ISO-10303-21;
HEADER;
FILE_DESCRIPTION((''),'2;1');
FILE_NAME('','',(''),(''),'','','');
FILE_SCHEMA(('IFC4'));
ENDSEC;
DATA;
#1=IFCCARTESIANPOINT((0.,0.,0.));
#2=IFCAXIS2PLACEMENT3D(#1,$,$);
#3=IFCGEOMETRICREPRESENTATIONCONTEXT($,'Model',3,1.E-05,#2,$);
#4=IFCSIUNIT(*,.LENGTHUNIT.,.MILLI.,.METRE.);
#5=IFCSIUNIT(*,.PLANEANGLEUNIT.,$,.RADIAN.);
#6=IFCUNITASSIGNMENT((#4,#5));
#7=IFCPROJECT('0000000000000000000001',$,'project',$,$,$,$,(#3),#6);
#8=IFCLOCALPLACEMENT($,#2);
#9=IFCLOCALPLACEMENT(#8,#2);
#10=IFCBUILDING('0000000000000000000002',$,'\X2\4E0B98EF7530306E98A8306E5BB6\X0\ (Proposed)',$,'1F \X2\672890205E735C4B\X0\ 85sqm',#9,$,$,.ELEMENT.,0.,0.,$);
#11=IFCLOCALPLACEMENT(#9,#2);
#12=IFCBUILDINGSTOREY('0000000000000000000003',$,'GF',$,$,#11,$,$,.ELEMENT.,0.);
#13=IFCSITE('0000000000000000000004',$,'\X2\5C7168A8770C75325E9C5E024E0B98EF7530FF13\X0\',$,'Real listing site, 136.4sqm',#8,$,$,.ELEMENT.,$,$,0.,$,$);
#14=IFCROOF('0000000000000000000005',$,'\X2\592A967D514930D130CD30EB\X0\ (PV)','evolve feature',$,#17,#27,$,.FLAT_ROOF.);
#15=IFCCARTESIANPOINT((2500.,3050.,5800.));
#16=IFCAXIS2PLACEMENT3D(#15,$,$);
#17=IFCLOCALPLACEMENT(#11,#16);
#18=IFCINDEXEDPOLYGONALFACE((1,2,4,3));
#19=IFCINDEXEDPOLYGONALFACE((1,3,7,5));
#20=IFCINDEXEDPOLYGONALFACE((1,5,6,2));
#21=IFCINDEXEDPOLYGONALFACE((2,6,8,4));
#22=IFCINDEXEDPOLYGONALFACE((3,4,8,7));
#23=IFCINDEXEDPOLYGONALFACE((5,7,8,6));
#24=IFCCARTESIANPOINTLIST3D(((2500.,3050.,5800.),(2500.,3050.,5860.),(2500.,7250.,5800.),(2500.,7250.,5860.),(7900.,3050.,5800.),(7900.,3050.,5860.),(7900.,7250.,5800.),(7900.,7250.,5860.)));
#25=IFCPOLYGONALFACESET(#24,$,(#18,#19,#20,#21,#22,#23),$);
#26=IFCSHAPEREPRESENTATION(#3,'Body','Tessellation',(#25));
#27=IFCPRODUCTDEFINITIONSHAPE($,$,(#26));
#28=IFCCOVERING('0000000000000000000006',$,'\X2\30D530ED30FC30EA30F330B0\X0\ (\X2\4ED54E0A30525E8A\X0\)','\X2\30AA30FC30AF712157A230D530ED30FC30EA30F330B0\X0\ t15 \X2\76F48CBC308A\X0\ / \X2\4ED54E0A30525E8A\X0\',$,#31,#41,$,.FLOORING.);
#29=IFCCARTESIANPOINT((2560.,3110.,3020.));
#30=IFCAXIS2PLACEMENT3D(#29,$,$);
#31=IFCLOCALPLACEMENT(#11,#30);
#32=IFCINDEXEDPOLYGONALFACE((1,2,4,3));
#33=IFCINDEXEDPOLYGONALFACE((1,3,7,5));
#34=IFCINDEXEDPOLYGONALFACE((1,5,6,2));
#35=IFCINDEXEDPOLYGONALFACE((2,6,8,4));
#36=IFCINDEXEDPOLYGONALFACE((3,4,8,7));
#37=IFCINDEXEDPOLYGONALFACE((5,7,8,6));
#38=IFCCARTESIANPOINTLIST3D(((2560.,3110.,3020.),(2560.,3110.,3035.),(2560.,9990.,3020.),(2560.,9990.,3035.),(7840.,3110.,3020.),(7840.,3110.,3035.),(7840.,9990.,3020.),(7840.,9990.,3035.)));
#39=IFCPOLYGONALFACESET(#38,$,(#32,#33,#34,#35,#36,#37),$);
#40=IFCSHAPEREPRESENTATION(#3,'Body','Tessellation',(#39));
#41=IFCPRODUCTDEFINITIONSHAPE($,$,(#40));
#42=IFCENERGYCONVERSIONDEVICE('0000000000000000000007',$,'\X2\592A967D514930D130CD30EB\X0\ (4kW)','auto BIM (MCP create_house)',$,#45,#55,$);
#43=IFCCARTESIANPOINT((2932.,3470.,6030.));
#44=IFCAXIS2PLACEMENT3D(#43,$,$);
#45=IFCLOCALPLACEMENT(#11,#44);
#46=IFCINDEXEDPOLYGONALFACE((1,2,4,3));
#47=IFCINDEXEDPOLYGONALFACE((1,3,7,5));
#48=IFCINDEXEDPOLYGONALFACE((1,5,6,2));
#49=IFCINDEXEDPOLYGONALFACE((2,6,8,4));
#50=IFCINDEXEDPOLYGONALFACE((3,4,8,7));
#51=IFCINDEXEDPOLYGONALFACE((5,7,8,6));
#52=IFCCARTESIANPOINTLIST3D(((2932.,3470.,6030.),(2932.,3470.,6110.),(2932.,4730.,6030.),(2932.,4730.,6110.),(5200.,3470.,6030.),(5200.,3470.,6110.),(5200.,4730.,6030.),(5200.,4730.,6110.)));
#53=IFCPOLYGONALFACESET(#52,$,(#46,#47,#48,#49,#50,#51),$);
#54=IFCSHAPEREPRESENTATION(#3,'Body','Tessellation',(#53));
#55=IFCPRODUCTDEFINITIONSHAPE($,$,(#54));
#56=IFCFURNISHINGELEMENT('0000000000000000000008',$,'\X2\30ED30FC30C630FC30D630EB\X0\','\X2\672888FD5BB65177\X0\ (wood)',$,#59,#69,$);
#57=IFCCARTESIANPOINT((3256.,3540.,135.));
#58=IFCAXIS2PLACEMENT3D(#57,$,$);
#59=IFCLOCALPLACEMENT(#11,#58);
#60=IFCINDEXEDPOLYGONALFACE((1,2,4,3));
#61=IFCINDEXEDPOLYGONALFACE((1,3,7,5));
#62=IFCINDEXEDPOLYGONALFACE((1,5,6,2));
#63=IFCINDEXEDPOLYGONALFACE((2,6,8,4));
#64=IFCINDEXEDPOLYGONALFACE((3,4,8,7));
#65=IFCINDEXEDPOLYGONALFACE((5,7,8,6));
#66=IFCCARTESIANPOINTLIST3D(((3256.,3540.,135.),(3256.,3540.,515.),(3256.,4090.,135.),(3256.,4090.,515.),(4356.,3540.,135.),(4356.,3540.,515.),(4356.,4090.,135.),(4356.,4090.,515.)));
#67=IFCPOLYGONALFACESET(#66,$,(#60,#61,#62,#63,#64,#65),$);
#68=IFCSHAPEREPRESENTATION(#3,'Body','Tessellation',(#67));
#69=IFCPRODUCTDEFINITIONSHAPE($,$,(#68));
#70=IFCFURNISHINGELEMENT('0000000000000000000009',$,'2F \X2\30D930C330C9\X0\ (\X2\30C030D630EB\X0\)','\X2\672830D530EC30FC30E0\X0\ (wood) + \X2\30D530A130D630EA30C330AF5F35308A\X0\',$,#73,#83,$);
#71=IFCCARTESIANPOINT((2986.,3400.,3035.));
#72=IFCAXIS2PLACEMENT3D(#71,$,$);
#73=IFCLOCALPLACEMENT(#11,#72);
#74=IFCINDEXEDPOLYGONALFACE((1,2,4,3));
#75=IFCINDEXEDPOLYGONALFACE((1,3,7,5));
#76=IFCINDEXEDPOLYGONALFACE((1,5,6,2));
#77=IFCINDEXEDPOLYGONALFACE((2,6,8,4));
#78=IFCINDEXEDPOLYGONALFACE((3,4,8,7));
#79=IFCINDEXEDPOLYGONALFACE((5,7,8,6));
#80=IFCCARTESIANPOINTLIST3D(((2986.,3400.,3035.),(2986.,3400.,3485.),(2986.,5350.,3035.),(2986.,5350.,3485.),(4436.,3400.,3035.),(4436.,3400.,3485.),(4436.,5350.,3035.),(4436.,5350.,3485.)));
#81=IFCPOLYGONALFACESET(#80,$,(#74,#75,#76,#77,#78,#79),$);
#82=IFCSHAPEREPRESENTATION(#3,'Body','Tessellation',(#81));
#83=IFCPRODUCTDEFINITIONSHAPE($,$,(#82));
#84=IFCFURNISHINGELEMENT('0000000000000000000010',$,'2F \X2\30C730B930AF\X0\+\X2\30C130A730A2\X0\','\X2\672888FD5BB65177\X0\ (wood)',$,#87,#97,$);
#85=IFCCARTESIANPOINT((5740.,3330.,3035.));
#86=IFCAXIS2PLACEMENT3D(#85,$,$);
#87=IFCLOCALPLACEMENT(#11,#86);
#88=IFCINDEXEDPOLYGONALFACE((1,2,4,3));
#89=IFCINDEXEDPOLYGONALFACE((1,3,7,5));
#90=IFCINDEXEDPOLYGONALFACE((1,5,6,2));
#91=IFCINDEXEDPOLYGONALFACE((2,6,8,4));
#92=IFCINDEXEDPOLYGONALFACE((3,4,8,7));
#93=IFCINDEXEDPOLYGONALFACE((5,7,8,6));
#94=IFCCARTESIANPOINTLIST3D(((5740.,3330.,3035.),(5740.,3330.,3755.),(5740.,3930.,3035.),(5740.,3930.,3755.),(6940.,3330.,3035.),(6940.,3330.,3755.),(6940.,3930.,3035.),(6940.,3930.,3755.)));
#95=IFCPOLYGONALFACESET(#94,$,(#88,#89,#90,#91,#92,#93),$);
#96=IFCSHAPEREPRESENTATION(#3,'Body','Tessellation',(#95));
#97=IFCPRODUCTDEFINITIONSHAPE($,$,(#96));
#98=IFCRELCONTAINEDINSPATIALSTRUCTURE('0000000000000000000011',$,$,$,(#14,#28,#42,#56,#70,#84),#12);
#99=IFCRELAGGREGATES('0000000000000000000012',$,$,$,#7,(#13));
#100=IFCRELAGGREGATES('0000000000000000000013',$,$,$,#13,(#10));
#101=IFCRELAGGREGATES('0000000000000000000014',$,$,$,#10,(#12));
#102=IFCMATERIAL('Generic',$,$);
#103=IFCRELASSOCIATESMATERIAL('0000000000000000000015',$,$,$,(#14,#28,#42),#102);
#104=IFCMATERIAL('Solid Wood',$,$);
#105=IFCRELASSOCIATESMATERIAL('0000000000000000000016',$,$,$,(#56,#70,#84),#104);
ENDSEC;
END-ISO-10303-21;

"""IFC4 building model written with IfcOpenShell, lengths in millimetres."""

from ifc_helpers import new_model, si_unit, frame, frame_2d, origin, place, context, project, spatial, rectangle, extrude, material, element, save


model = new_model("IFC4")

# Units and contexts
model_context = context("Model", 3, precision=1e-05, world=origin())
ifc_project = project(units=[si_unit("LENGTHUNIT", "METRE", prefix="MILLI"), si_unit("PLANEANGLEUNIT", "RADIAN")], contexts=[model_context])

# Site, building, storey
site_placement = place(None, origin())
site = spatial("IfcSite", under=ifc_project, at=site_placement, Name="山梨県甲府市下飯田３", ObjectType="Real listing site, 136.4sqm", CompositionType="ELEMENT", RefElevation=0.0)
building_placement = place(site_placement, origin())
building = spatial("IfcBuilding", under=site, at=building_placement, Name="下飯田の風の家 (Proposed)", ObjectType="1F 木造平屋 85sqm", CompositionType="ELEMENT", ElevationOfRefHeight=0.0, ElevationOfTerrain=0.0)
storey_placement = place(building_placement, origin())
storey = spatial("IfcBuildingStorey", under=building, at=storey_placement, Name="GF", CompositionType="ELEMENT", Elevation=0.0)

# Shared definitions
ifc_material_1 = material(Name="Solid Wood")

# Shared definitions
ifc_material_2 = material(Name="Generic")

# Roof
roof_1_placement = place(storey_placement, frame((2500.0, 3050.0, 5800.0)))
element("IfcRoof", 1, at=roof_1_placement, inside=storey, material=ifc_material_2, Name="太陽光パネル (PV)", Description="evolve feature", PredefinedType="FLAT_ROOF", context=model_context, shape_type="SweptSolid", body=[
    extrude(rectangle(XDim=5400.0, YDim=4200.0, at=frame_2d((2700.0, 2100.0))), frame((2500.0, 3050.0, 5800.0)), (0.0, 0.0, 1.0), 60.0),
])

# Covering
covering_placement = place(storey_placement, frame((2560.0, 3110.0, 3020.0)))
element("IfcCovering", 2, at=covering_placement, inside=storey, material=ifc_material_2, Name="フローリング (仕上げ床)", Description="オーク無垢フローリング t15 直貼り / 仕上げ床", PredefinedType="FLOORING", context=model_context, shape_type="SweptSolid", body=[
    extrude(rectangle(XDim=5280.0, YDim=6880.0, at=frame_2d((2640.0, 3440.0))), frame((2560.0, 3110.0, 3020.0)), (0.0, 0.0, 1.0), 15.0),
])

# Energy conversion device
energy_conversion_device_placement = place(storey_placement, frame((2932.0, 3470.0, 6030.0)))
element("IfcEnergyConversionDevice", 3, at=energy_conversion_device_placement, inside=storey, material=ifc_material_2, Name="太陽光パネル (4kW)", Description="auto BIM (MCP create_house)", context=model_context, shape_type="SweptSolid", body=[
    extrude(rectangle(XDim=2268.0, YDim=1260.0, at=frame_2d((1134.0, 630.0))), frame((2932.0, 3470.0, 6030.0)), (0.0, 0.0, 1.0), 80.0),
])

# Furnishing elements
furnishing_1_placement = place(storey_placement, frame((3256.0, 3540.0, 135.0)))
element("IfcFurnishingElement", 4, at=furnishing_1_placement, inside=storey, material=ifc_material_1, Name="ローテーブル", Description="木製家具 (wood)", context=model_context, shape_type="SweptSolid", body=[
    extrude(rectangle(XDim=1100.0, YDim=550.0, at=frame_2d((550.0, 275.0))), frame((3256.0, 3540.0, 135.0)), (0.0, 0.0, 1.0), 380.0),
])
furnishing_2_placement = place(storey_placement, frame((2986.0, 3400.0, 3035.0)))
element("IfcFurnishingElement", 5, at=furnishing_2_placement, inside=storey, material=ifc_material_1, Name="2F ベッド (ダブル)", Description="木フレーム (wood) + ファブリック張り", context=model_context, shape_type="SweptSolid", body=[
    extrude(rectangle(XDim=1450.0, YDim=1950.0, at=frame_2d((725.0, 975.0))), frame((2986.0, 3400.0, 3035.0)), (0.0, 0.0, 1.0), 450.0),
])
furnishing_3_placement = place(storey_placement, frame((5740.0, 3330.0, 3035.0)))
element("IfcFurnishingElement", 6, at=furnishing_3_placement, inside=storey, material=ifc_material_1, Name="2F デスク+チェア", Description="木製家具 (wood)", context=model_context, shape_type="SweptSolid", body=[
    extrude(rectangle(XDim=1200.0, YDim=600.0, at=frame_2d((600.0, 300.0))), frame((5740.0, 3330.0, 3035.0)), (0.0, 0.0, 1.0), 720.0),
])

save(model, "model.ifc")
